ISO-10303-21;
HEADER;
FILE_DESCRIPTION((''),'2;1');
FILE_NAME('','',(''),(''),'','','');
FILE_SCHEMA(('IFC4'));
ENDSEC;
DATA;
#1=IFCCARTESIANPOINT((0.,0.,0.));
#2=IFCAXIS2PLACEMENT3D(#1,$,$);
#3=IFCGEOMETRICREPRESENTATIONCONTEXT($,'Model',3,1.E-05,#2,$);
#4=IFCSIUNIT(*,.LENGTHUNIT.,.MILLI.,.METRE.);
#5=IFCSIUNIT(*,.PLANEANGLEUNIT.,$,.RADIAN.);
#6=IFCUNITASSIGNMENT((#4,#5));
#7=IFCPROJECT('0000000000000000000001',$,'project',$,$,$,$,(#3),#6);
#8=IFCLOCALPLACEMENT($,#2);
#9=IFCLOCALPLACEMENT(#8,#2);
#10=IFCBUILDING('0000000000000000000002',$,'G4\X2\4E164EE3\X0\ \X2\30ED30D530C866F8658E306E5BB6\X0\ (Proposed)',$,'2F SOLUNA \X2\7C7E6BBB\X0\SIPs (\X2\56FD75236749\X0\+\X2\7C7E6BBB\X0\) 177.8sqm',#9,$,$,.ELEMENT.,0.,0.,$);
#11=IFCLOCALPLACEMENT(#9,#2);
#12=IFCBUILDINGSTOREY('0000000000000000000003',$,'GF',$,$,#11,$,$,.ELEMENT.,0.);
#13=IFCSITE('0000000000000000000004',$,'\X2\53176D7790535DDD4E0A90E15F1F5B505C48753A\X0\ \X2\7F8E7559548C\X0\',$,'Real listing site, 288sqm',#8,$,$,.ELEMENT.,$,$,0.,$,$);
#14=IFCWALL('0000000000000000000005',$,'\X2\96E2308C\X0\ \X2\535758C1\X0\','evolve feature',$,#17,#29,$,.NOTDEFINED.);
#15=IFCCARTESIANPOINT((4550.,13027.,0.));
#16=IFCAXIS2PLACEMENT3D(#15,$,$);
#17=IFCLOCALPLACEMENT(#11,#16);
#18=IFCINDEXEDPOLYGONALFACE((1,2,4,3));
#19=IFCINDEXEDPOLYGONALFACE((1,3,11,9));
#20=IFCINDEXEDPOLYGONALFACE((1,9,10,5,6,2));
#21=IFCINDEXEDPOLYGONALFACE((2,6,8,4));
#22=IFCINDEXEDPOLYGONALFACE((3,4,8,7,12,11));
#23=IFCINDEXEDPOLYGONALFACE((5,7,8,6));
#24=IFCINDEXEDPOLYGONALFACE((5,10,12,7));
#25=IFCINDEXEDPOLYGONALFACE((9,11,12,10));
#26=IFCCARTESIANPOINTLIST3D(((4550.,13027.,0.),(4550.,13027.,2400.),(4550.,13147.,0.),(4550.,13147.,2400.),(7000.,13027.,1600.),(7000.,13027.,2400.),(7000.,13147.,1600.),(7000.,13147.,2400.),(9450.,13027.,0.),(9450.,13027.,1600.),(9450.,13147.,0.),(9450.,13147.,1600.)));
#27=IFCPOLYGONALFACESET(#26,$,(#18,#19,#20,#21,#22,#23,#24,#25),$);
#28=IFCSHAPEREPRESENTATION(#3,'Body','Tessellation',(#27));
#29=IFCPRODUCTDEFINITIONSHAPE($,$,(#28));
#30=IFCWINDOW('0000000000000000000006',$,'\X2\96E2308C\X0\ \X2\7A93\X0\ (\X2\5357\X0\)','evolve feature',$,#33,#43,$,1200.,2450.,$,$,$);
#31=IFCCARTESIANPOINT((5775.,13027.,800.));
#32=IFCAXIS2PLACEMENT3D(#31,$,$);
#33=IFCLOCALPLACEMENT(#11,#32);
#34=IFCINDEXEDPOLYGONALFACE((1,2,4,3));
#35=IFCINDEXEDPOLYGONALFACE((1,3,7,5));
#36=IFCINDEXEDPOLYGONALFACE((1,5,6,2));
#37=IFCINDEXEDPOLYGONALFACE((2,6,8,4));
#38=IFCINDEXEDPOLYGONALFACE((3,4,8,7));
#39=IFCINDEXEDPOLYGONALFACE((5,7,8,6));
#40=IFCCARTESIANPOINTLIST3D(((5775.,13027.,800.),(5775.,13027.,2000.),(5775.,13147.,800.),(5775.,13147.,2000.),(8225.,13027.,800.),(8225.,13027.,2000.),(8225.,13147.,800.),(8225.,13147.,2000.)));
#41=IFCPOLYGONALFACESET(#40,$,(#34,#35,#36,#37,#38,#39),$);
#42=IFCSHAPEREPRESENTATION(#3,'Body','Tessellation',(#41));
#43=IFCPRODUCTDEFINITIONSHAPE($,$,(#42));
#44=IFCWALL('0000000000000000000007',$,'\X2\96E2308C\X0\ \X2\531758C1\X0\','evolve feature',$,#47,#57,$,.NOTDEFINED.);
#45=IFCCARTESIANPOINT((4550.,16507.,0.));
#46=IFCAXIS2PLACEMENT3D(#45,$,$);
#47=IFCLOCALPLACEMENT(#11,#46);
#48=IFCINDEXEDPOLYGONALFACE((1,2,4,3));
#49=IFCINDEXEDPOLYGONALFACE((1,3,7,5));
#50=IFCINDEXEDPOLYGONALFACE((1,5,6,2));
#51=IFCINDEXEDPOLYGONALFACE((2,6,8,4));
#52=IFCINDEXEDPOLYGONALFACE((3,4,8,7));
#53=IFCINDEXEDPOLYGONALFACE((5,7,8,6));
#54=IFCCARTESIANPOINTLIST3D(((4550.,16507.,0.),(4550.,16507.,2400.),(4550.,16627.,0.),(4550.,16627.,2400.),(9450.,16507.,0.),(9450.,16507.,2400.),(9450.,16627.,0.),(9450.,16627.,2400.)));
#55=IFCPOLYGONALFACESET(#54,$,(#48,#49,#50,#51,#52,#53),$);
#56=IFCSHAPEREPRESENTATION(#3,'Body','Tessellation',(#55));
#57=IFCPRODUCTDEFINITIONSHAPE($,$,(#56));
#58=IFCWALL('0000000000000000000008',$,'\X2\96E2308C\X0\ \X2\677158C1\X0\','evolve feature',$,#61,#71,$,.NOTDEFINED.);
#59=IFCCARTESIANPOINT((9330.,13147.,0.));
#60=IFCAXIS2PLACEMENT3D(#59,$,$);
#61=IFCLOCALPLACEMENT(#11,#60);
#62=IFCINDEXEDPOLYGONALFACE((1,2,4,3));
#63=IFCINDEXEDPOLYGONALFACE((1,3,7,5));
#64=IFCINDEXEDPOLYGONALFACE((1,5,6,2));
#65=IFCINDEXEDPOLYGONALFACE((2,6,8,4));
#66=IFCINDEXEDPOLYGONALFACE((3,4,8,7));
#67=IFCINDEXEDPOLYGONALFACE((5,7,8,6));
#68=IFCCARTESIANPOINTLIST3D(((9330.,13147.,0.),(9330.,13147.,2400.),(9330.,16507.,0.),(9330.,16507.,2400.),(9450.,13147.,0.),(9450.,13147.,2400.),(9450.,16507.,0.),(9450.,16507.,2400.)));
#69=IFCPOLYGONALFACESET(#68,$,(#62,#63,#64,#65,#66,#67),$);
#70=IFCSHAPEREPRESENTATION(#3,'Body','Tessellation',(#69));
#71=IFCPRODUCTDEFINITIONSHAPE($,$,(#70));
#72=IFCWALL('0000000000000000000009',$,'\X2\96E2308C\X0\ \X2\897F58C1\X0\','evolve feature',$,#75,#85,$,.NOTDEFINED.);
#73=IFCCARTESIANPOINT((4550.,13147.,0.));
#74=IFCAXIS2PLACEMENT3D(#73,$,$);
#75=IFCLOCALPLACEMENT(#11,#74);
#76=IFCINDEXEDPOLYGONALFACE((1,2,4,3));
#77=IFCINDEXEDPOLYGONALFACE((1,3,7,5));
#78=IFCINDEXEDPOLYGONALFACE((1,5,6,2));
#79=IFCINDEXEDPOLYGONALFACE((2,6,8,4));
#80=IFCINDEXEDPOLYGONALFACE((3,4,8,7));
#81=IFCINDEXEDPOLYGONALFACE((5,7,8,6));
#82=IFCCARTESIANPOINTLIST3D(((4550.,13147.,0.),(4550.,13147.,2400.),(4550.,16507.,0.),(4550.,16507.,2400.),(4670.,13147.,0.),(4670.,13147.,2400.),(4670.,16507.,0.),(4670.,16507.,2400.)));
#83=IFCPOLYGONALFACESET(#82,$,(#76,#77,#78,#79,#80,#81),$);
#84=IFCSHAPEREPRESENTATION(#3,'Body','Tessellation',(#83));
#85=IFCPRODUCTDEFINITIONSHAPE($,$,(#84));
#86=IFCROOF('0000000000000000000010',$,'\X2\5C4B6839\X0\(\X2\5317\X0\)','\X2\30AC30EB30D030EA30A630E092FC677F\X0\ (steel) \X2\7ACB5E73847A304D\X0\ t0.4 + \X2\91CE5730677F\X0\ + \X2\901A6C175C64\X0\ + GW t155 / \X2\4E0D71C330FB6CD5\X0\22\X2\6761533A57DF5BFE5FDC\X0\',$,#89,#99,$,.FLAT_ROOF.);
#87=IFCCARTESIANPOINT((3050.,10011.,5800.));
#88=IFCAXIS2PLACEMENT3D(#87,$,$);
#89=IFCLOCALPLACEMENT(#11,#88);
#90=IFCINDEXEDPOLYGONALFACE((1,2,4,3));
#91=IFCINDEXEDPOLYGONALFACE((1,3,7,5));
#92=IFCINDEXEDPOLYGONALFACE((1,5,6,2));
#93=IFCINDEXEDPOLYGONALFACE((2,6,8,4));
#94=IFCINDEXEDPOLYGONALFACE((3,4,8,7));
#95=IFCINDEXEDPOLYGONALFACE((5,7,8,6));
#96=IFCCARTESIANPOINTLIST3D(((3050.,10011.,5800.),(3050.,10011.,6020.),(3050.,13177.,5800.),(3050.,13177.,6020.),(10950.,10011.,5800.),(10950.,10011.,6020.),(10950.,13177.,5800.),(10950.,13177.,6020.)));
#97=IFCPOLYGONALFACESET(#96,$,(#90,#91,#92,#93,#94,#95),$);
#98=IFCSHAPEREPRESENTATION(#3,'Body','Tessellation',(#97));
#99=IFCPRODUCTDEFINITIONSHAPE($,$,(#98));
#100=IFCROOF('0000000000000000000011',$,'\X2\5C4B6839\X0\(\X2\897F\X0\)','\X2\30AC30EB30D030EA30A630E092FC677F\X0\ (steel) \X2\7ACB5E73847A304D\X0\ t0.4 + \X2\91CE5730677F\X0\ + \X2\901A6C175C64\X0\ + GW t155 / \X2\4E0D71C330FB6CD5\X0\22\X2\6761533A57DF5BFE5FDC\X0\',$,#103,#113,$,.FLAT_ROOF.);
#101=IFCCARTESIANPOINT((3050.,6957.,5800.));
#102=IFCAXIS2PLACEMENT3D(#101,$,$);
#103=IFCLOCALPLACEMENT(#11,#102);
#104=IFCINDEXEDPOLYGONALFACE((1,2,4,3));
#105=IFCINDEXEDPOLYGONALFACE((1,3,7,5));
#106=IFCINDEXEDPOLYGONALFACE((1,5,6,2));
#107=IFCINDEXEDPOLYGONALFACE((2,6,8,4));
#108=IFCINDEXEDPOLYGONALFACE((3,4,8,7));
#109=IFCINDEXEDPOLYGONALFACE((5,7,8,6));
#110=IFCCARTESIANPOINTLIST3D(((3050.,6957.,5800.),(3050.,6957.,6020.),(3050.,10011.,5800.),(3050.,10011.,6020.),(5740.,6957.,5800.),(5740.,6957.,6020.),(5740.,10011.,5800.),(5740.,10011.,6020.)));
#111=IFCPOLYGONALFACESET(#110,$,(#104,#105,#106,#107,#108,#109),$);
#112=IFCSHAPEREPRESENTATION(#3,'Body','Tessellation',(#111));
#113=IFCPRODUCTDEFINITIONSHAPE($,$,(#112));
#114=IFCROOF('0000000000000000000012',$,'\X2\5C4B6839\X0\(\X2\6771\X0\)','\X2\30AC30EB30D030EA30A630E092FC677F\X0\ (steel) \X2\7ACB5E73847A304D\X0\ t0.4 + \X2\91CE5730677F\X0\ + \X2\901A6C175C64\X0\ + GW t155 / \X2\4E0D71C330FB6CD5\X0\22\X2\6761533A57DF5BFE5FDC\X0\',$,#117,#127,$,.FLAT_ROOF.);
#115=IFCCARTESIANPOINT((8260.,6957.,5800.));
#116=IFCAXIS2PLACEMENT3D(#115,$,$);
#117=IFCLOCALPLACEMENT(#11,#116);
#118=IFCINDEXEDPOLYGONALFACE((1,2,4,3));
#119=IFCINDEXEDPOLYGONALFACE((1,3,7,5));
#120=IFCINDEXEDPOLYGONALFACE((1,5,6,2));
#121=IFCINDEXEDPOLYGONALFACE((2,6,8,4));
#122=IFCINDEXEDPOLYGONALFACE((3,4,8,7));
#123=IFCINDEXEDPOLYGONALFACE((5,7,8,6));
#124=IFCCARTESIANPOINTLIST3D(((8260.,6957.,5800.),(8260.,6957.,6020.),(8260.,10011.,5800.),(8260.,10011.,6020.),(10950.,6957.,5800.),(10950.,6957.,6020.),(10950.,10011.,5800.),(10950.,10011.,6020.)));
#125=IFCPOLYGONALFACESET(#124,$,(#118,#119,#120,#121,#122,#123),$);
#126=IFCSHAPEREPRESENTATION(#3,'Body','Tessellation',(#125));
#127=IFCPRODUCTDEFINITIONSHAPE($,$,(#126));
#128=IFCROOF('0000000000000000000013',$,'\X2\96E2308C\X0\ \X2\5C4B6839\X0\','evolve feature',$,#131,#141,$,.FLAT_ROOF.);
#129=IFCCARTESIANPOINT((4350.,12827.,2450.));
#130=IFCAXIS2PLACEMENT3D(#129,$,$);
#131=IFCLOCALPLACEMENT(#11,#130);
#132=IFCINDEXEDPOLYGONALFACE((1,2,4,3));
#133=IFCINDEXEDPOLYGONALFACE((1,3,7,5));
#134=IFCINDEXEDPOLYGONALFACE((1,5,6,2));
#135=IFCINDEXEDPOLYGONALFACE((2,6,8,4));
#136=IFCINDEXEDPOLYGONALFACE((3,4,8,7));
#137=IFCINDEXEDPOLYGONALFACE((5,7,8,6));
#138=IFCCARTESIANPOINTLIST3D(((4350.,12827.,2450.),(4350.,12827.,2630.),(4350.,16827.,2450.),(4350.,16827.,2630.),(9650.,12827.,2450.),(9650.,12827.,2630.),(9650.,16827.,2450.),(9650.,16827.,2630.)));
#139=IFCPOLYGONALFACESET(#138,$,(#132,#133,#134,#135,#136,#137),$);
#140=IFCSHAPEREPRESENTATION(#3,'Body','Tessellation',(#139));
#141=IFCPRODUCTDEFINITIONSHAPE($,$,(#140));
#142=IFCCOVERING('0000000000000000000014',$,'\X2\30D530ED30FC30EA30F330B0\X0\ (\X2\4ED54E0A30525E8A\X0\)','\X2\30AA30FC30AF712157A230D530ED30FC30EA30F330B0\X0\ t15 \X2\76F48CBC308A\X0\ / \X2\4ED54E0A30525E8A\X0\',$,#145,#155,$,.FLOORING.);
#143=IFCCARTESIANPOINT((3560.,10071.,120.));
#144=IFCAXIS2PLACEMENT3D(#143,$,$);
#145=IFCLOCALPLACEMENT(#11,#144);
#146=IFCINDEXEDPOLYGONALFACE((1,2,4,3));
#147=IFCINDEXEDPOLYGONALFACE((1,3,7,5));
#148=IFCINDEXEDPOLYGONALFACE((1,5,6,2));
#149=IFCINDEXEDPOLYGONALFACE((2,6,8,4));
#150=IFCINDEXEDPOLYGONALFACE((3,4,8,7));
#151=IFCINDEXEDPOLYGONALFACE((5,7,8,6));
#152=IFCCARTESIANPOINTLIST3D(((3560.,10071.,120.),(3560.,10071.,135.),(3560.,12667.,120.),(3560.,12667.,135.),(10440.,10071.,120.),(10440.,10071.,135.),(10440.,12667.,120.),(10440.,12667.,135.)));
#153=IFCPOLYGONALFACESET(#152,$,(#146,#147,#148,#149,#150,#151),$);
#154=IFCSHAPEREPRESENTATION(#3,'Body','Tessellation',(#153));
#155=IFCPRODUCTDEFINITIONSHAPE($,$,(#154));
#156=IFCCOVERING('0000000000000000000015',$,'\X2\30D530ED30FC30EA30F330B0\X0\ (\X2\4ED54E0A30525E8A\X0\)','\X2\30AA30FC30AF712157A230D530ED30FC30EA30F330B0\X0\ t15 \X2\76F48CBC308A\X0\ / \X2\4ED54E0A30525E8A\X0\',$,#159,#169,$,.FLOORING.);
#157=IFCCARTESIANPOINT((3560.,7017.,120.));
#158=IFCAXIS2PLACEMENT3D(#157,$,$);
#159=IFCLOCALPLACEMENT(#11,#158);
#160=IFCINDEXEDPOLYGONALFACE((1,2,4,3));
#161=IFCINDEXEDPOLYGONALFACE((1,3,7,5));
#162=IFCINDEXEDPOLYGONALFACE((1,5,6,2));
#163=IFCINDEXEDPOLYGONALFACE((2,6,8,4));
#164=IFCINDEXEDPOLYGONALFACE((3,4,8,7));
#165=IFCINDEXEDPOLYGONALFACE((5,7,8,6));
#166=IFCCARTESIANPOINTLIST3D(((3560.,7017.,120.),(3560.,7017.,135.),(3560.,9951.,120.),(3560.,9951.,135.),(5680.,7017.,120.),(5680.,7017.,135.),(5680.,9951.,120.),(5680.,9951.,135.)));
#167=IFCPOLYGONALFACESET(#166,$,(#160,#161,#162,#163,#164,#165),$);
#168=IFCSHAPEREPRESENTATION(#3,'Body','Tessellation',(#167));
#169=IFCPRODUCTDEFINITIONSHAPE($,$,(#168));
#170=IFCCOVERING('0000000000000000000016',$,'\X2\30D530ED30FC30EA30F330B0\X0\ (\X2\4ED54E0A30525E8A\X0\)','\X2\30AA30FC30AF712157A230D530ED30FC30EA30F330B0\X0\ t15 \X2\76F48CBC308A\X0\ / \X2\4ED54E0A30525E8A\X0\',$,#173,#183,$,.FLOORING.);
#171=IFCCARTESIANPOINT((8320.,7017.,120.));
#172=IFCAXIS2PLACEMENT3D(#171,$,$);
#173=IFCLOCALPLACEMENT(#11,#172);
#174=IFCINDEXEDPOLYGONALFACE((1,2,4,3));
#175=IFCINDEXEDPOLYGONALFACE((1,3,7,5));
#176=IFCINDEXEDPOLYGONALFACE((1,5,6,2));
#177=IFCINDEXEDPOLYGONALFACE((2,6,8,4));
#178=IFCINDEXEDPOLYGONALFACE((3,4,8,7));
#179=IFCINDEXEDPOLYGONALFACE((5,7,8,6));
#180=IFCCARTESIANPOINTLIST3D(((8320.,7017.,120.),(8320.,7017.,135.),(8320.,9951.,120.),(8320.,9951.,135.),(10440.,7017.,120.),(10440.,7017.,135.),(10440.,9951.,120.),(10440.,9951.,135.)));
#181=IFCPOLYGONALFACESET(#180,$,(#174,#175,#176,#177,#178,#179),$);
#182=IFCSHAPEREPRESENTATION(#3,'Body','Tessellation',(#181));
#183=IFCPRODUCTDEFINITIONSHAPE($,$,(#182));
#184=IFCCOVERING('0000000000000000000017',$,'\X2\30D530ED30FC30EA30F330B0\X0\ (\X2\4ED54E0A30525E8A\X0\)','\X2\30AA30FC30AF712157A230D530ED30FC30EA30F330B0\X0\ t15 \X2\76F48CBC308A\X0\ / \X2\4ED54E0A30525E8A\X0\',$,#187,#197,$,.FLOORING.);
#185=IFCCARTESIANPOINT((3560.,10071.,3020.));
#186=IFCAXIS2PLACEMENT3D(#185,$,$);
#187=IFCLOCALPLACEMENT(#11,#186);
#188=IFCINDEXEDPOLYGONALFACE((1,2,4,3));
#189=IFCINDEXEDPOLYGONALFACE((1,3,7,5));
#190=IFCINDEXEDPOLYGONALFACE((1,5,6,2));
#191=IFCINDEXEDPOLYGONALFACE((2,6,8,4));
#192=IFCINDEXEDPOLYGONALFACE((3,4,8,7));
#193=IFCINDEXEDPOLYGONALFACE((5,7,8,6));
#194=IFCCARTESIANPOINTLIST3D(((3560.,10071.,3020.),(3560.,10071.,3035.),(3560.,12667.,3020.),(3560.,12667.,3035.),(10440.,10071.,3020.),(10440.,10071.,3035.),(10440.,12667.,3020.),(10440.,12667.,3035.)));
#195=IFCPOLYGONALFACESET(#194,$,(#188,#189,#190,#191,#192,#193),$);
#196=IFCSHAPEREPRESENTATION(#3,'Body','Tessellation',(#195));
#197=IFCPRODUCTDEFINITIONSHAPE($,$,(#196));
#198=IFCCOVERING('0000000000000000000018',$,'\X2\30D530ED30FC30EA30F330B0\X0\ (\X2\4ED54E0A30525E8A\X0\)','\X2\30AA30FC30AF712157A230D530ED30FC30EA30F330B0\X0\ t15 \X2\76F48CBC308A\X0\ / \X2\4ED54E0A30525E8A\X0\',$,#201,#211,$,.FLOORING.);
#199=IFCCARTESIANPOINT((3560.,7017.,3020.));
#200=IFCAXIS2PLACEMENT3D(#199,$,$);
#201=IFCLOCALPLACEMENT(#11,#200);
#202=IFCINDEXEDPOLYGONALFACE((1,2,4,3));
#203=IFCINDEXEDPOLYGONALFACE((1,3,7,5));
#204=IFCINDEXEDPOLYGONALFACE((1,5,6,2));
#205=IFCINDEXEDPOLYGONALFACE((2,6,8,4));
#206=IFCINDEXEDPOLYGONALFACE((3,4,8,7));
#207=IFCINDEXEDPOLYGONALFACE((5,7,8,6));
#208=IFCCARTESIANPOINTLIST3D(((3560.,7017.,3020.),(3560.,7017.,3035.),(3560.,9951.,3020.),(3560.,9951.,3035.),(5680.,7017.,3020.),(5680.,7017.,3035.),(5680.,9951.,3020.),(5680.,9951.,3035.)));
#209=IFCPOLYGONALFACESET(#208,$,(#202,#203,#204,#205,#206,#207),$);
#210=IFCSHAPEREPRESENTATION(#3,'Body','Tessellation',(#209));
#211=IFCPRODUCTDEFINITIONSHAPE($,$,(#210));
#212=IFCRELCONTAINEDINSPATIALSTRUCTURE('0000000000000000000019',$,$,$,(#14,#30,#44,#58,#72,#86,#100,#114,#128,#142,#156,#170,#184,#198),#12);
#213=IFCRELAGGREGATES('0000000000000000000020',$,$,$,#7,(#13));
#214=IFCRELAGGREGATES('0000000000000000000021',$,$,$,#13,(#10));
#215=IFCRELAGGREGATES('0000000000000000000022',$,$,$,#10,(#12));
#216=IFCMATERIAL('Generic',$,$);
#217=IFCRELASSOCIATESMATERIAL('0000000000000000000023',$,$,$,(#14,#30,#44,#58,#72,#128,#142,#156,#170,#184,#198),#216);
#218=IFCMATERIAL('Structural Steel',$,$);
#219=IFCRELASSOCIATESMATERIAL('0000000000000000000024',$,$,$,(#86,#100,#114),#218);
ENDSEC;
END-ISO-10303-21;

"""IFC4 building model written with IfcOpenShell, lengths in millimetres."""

from ifc_helpers import new_model, si_unit, frame, frame_2d, origin, place, context, project, spatial, rectangle, extrude, material, element, fill, save


model = new_model("IFC4")

# Units and contexts
model_context = context("Model", 3, precision=1e-05, world=origin())
ifc_project = project(units=[si_unit("LENGTHUNIT", "METRE", prefix="MILLI"), si_unit("PLANEANGLEUNIT", "RADIAN")], contexts=[model_context])

# Site, building, storey
site_placement = place(None, origin())
site = spatial("IfcSite", under=ifc_project, at=site_placement, Name="北海道川上郡弟子屈町 美留和", ObjectType="Real listing site, 288sqm", CompositionType="ELEMENT", RefElevation=0.0)
building_placement = place(site_placement, origin())
building = spatial("IfcBuilding", under=site, at=building_placement, Name="G4世代 ロフト書斎の家 (Proposed)", ObjectType="2F SOLUNA 籾殻SIPs (国産杉+籾殻) 177.8sqm", CompositionType="ELEMENT", ElevationOfRefHeight=0.0, ElevationOfTerrain=0.0)
storey_placement = place(building_placement, origin())
storey = spatial("IfcBuildingStorey", under=building, at=storey_placement, Name="GF", CompositionType="ELEMENT", Elevation=0.0)

# Shared definitions
ifc_material_1 = material(Name="Generic")

# Wall, opening, window
wall_1_placement = place(storey_placement, frame((4550.0, 13027.0, 0.0)))
wall_1 = element("IfcWall", 1, at=wall_1_placement, inside=storey, material=ifc_material_1, Name="離れ 南壁", Description="evolve feature", PredefinedType="NOTDEFINED", context=model_context, shape_type="SweptSolid", body=[
    extrude(rectangle(XDim=4900.0, YDim=120.0, at=frame_2d((2450.0, 60.0))), frame((4550.0, 13027.0, 0.0)), (0.0, 0.0, 1.0), 2400.0),
])
opening_1_placement = place(storey_placement, frame((5775.0, 13027.0, 800.0)))
opening_1 = element("IfcOpeningElement", 2, at=opening_1_placement, cuts=wall_1, PredefinedType="NOTDEFINED", context=model_context, shape_type="SweptSolid", body=[
    extrude(rectangle(XDim=2450.0, YDim=120.0, at=frame_2d((1225.0, 60.0))), frame((5775.0, 13027.0, 800.0)), (0.0, 0.0, 1.0), 1200.0),
])
window_1_placement = place(storey_placement, frame((5775.0, 13027.0, 800.0)))
window_1 = element("IfcWindow", 3, at=window_1_placement, inside=storey, material=ifc_material_1, Name="離れ 窓 (南)", Description="evolve feature", OverallHeight=1200.0, OverallWidth=2450.0, context=model_context, shape_type="SweptSolid", body=[
    extrude(rectangle(XDim=2450.0, YDim=120.0, at=frame_2d((1225.0, 60.0))), frame((5775.0, 13027.0, 800.0)), (0.0, 0.0, 1.0), 1200.0),
])
fill(opening_1, window_1)

# Walls
wall_2_placement = place(storey_placement, frame((4550.0, 16507.0, 0.0)))
element("IfcWall", 4, at=wall_2_placement, inside=storey, material=ifc_material_1, Name="離れ 北壁", Description="evolve feature", PredefinedType="NOTDEFINED", context=model_context, shape_type="SweptSolid", body=[
    extrude(rectangle(XDim=4900.0, YDim=120.0, at=frame_2d((2450.0, 60.0))), frame((4550.0, 16507.0, 0.0)), (0.0, 0.0, 1.0), 2400.0),
])
wall_3_placement = place(storey_placement, frame((9330.0, 13147.0, 0.0)))
element("IfcWall", 5, at=wall_3_placement, inside=storey, material=ifc_material_1, Name="離れ 東壁", Description="evolve feature", PredefinedType="NOTDEFINED", context=model_context, shape_type="SweptSolid", body=[
    extrude(rectangle(XDim=120.0, YDim=3360.0, at=frame_2d((60.0, 1680.0))), frame((9330.0, 13147.0, 0.0)), (0.0, 0.0, 1.0), 2400.0),
])
wall_4_placement = place(storey_placement, frame((4550.0, 13147.0, 0.0)))
element("IfcWall", 6, at=wall_4_placement, inside=storey, material=ifc_material_1, Name="離れ 西壁", Description="evolve feature", PredefinedType="NOTDEFINED", context=model_context, shape_type="SweptSolid", body=[
    extrude(rectangle(XDim=120.0, YDim=3360.0, at=frame_2d((60.0, 1680.0))), frame((4550.0, 13147.0, 0.0)), (0.0, 0.0, 1.0), 2400.0),
])

# Roofs
ifc_material_2 = material(Name="Structural Steel")
for number, where, name in (
    (7, (3050.0, 10011.0, 5800.0), "屋根(北)"),
):
    element("IfcRoof", number, at=place(storey_placement, frame(where)), inside=storey, material=ifc_material_2, Name=name, Description="ガルバリウム鋼板 (steel) 立平葺き t0.4 + 野地板 + 通気層 + GW t155 / 不燃・法22条区域対応", PredefinedType="FLAT_ROOF", context=model_context, shape_type="SweptSolid", body=[
        extrude(rectangle(XDim=7900.0, YDim=3166.0, at=frame_2d((3950.0, 1583.0))), frame((3050.0, 10011.0, 5800.0)), (0.0, 0.0, 1.0), 220.0),
    ])
roof_1_placement = place(storey_placement, frame((3050.0, 6957.0, 5800.0)))
element("IfcRoof", 8, at=roof_1_placement, inside=storey, material=ifc_material_2, Name="屋根(西)", Description="ガルバリウム鋼板 (steel) 立平葺き t0.4 + 野地板 + 通気層 + GW t155 / 不燃・法22条区域対応", PredefinedType="FLAT_ROOF", context=model_context, shape_type="SweptSolid", body=[
    extrude(rectangle(XDim=2690.0, YDim=3054.0, at=frame_2d((1345.0, 1527.0))), frame((3050.0, 6957.0, 5800.0)), (0.0, 0.0, 1.0), 220.0),
])
roof_2_placement = place(storey_placement, frame((8260.0, 6957.0, 5800.0)))
element("IfcRoof", 9, at=roof_2_placement, inside=storey, material=ifc_material_2, Name="屋根(東)", Description="ガルバリウム鋼板 (steel) 立平葺き t0.4 + 野地板 + 通気層 + GW t155 / 不燃・法22条区域対応", PredefinedType="FLAT_ROOF", context=model_context, shape_type="SweptSolid", body=[
    extrude(rectangle(XDim=2690.0, YDim=3054.0, at=frame_2d((1345.0, 1527.0))), frame((8260.0, 6957.0, 5800.0)), (0.0, 0.0, 1.0), 220.0),
])
roof_3_placement = place(storey_placement, frame((4350.0, 12827.0, 2450.0)))
element("IfcRoof", 10, at=roof_3_placement, inside=storey, material=ifc_material_1, Name="離れ 屋根", Description="evolve feature", PredefinedType="FLAT_ROOF", context=model_context, shape_type="SweptSolid", body=[
    extrude(rectangle(XDim=5300.0, YDim=4000.0, at=frame_2d((2650.0, 2000.0))), frame((4350.0, 12827.0, 2450.0)), (0.0, 0.0, 1.0), 180.0),
])

# Coverings
covering_1_placement = place(storey_placement, frame((3560.0, 10071.0, 120.0)))
element("IfcCovering", 11, at=covering_1_placement, inside=storey, material=ifc_material_1, Name="フローリング (仕上げ床)", Description="オーク無垢フローリング t15 直貼り / 仕上げ床", PredefinedType="FLOORING", context=model_context, shape_type="SweptSolid", body=[
    extrude(rectangle(XDim=6880.0, YDim=2596.0, at=frame_2d((3440.0, 1298.0))), frame((3560.0, 10071.0, 120.0)), (0.0, 0.0, 1.0), 15.0),
])
covering_2_placement = place(storey_placement, frame((3560.0, 7017.0, 120.0)))
element("IfcCovering", 12, at=covering_2_placement, inside=storey, material=ifc_material_1, Name="フローリング (仕上げ床)", Description="オーク無垢フローリング t15 直貼り / 仕上げ床", PredefinedType="FLOORING", context=model_context, shape_type="SweptSolid", body=[
    extrude(rectangle(XDim=2120.0, YDim=2934.0, at=frame_2d((1060.0, 1467.0))), frame((3560.0, 7017.0, 120.0)), (0.0, 0.0, 1.0), 15.0),
])
covering_3_placement = place(storey_placement, frame((8320.0, 7017.0, 120.0)))
element("IfcCovering", 13, at=covering_3_placement, inside=storey, material=ifc_material_1, Name="フローリング (仕上げ床)", Description="オーク無垢フローリング t15 直貼り / 仕上げ床", PredefinedType="FLOORING", context=model_context, shape_type="SweptSolid", body=[
    extrude(rectangle(XDim=2120.0, YDim=2934.0, at=frame_2d((1060.0, 1467.0))), frame((8320.0, 7017.0, 120.0)), (0.0, 0.0, 1.0), 15.0),
])
covering_4_placement = place(storey_placement, frame((3560.0, 10071.0, 3020.0)))
element("IfcCovering", 14, at=covering_4_placement, inside=storey, material=ifc_material_1, Name="フローリング (仕上げ床)", Description="オーク無垢フローリング t15 直貼り / 仕上げ床", PredefinedType="FLOORING", context=model_context, shape_type="SweptSolid", body=[
    extrude(rectangle(XDim=6880.0, YDim=2596.0, at=frame_2d((3440.0, 1298.0))), frame((3560.0, 10071.0, 3020.0)), (0.0, 0.0, 1.0), 15.0),
])
covering_5_placement = place(storey_placement, frame((3560.0, 7017.0, 3020.0)))
element("IfcCovering", 15, at=covering_5_placement, inside=storey, material=ifc_material_1, Name="フローリング (仕上げ床)", Description="オーク無垢フローリング t15 直貼り / 仕上げ床", PredefinedType="FLOORING", context=model_context, shape_type="SweptSolid", body=[
    extrude(rectangle(XDim=2120.0, YDim=2934.0, at=frame_2d((1060.0, 1467.0))), frame((3560.0, 7017.0, 3020.0)), (0.0, 0.0, 1.0), 15.0),
])

save(model, "model.ifc")
